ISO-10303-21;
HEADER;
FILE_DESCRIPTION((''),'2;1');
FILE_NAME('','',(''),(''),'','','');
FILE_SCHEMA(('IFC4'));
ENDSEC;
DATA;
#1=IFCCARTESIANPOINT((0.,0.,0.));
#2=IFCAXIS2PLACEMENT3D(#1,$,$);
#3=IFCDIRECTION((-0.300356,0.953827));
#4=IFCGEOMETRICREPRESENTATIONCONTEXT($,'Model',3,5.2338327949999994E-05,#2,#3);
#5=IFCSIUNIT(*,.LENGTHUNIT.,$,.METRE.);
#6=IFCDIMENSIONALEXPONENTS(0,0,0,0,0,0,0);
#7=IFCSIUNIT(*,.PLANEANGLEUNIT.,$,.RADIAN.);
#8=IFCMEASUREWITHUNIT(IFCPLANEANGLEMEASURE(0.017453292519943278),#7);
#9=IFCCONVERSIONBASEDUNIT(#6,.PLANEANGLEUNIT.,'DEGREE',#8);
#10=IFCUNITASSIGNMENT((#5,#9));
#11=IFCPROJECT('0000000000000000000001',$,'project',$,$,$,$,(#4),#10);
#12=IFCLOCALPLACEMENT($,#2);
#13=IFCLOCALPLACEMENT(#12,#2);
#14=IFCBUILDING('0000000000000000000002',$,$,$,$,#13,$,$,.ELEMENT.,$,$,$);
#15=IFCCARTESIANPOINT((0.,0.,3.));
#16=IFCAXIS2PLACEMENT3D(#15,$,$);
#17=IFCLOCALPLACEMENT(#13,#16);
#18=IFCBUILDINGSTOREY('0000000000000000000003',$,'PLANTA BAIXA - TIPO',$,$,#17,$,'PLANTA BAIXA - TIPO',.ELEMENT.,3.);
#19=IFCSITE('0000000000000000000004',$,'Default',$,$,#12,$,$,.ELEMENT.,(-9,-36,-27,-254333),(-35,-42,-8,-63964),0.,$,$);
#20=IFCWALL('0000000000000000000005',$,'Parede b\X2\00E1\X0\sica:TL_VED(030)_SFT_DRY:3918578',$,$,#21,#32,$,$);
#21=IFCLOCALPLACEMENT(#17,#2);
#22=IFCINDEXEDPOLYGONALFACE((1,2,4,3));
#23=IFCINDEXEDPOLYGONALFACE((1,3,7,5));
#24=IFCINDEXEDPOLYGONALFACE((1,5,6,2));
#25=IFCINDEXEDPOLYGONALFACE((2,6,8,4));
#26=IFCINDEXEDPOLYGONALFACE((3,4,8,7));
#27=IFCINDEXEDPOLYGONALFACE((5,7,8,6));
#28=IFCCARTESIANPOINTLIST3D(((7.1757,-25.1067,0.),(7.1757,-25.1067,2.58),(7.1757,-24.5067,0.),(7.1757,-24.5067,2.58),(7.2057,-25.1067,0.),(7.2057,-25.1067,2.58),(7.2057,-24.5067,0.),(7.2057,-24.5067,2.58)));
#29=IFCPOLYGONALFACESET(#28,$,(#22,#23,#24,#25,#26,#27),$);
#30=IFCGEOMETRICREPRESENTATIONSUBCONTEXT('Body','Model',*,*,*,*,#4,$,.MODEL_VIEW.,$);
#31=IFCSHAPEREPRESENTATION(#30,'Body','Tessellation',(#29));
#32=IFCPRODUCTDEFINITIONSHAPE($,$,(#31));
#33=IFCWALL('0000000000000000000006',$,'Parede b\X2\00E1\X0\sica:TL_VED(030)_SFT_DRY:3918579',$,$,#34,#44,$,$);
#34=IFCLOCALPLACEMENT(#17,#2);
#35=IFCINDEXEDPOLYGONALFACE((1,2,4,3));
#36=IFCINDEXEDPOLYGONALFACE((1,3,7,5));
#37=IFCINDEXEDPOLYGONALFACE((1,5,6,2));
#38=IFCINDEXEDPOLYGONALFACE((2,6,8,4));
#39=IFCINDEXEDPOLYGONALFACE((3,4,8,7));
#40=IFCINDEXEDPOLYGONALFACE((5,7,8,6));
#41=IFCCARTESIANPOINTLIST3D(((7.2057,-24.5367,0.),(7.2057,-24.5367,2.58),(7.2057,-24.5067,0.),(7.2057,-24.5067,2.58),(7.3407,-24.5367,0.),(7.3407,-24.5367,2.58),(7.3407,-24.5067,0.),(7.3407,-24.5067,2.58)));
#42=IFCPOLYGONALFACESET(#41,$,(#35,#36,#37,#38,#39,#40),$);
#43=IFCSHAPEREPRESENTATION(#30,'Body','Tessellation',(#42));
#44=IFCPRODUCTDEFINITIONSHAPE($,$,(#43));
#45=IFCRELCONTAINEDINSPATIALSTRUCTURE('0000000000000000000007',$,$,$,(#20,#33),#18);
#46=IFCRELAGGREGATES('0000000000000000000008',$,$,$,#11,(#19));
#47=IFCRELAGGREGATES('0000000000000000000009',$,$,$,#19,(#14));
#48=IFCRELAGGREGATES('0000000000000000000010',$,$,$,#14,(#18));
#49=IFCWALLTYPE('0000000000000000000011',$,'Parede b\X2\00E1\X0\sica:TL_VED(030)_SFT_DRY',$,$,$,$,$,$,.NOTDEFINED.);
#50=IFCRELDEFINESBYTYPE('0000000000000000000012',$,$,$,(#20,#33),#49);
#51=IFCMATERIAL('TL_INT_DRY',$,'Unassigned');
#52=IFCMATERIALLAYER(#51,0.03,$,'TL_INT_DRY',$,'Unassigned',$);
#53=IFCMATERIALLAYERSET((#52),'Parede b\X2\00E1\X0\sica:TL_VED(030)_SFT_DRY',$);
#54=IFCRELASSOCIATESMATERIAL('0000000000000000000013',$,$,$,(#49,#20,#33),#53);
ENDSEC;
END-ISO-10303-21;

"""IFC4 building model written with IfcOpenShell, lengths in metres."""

from ifc_helpers import new_model, entity, si_unit, converted_unit, direction, frame, frame_2d, origin, place, context, subcontext, project, spatial, rectangle, extrude, material, layer, layer_set, layer_usage, type_object, element, save


model = new_model("IFC4")

# Units and contexts
model_context = context("Model", 3, precision=5.2338327949999994e-05, world=origin(), true_north=direction((-0.300356, 0.953827)))
body_context = subcontext(model_context, "Body", "Model", "MODEL_VIEW")
ifc_project = project(units=[si_unit("LENGTHUNIT", "METRE"), converted_unit("PLANEANGLEUNIT", "DEGREE", entity("IfcPlaneAngleMeasure", 0.017453292519943278), si_unit("PLANEANGLEUNIT", "RADIAN"), dimensions=[0, 0, 0, 0, 0, 0, 0])], contexts=[model_context])

# Site, building, storey
site_placement = place(None, origin())
site = spatial("IfcSite", under=ifc_project, at=site_placement, Name="Default", CompositionType="ELEMENT", RefLatitude=(-9, -36, -27, -254333), RefLongitude=(-35, -42, -8, -63964), RefElevation=0.0)
building_placement = place(site_placement, origin())
building = spatial("IfcBuilding", under=site, at=building_placement, CompositionType="ELEMENT")
storey_placement = place(building_placement, frame((0.0, 0.0, 3.0)))
storey = spatial("IfcBuildingStorey", under=building, at=storey_placement, Name="PLANTA BAIXA - TIPO", LongName="PLANTA BAIXA - TIPO", CompositionType="ELEMENT", Elevation=3.0)

# Walls
ifc_material_1 = material(Name="TL_INT_DRY", Category="Unassigned")
ifc_layer_1 = layer(ifc_material_1, 0.03, Name="TL_INT_DRY", Category="Unassigned")
ifc_layer_set_1 = layer_set([ifc_layer_1], Name="Parede básica:TL_VED(030)_SFT_DRY")
ifc_layer_usage_1 = layer_usage(ifc_layer_set_1, "AXIS2", "NEGATIVE", 0.015)
wall_type_1 = type_object("IfcWallType", Name="Parede básica:TL_VED(030)_SFT_DRY", PredefinedType="NOTDEFINED", material=ifc_layer_set_1)
wall_1_placement = place(storey_placement, frame((7.1907, -25.1067, 0.0), z_axis=(0.0, 0.0, 1.0), x_axis=(0.0, 1.0, 0.0)))
element("IfcWall", 1, at=wall_1_placement, inside=storey, type_object=wall_type_1, material=ifc_layer_usage_1, Name="Parede básica:TL_VED(030)_SFT_DRY:3918578", context=body_context, shape_type="SweptSolid", body=[
    extrude(rectangle(XDim=0.6, YDim=0.03, at=frame_2d((0.3, 0.0), x_axis=(-1.0, 0.0))), origin(), (0.0, 0.0, 1.0), 2.58),
])
ifc_layer_usage_2 = layer_usage(ifc_layer_set_1, "AXIS2", "NEGATIVE", 0.015)
wall_2_placement = place(storey_placement, frame((7.2057, -24.5217, 0.0)))
element("IfcWall", 2, at=wall_2_placement, inside=storey, type_object=wall_type_1, material=ifc_layer_usage_2, Name="Parede básica:TL_VED(030)_SFT_DRY:3918579", context=body_context, shape_type="SweptSolid", body=[
    extrude(rectangle(XDim=0.135, YDim=0.03, at=frame_2d((0.0675, 0.0), x_axis=(-1.0, 0.0))), origin(), (0.0, 0.0, 1.0), 2.58),
])

save(model, "model.ifc")
